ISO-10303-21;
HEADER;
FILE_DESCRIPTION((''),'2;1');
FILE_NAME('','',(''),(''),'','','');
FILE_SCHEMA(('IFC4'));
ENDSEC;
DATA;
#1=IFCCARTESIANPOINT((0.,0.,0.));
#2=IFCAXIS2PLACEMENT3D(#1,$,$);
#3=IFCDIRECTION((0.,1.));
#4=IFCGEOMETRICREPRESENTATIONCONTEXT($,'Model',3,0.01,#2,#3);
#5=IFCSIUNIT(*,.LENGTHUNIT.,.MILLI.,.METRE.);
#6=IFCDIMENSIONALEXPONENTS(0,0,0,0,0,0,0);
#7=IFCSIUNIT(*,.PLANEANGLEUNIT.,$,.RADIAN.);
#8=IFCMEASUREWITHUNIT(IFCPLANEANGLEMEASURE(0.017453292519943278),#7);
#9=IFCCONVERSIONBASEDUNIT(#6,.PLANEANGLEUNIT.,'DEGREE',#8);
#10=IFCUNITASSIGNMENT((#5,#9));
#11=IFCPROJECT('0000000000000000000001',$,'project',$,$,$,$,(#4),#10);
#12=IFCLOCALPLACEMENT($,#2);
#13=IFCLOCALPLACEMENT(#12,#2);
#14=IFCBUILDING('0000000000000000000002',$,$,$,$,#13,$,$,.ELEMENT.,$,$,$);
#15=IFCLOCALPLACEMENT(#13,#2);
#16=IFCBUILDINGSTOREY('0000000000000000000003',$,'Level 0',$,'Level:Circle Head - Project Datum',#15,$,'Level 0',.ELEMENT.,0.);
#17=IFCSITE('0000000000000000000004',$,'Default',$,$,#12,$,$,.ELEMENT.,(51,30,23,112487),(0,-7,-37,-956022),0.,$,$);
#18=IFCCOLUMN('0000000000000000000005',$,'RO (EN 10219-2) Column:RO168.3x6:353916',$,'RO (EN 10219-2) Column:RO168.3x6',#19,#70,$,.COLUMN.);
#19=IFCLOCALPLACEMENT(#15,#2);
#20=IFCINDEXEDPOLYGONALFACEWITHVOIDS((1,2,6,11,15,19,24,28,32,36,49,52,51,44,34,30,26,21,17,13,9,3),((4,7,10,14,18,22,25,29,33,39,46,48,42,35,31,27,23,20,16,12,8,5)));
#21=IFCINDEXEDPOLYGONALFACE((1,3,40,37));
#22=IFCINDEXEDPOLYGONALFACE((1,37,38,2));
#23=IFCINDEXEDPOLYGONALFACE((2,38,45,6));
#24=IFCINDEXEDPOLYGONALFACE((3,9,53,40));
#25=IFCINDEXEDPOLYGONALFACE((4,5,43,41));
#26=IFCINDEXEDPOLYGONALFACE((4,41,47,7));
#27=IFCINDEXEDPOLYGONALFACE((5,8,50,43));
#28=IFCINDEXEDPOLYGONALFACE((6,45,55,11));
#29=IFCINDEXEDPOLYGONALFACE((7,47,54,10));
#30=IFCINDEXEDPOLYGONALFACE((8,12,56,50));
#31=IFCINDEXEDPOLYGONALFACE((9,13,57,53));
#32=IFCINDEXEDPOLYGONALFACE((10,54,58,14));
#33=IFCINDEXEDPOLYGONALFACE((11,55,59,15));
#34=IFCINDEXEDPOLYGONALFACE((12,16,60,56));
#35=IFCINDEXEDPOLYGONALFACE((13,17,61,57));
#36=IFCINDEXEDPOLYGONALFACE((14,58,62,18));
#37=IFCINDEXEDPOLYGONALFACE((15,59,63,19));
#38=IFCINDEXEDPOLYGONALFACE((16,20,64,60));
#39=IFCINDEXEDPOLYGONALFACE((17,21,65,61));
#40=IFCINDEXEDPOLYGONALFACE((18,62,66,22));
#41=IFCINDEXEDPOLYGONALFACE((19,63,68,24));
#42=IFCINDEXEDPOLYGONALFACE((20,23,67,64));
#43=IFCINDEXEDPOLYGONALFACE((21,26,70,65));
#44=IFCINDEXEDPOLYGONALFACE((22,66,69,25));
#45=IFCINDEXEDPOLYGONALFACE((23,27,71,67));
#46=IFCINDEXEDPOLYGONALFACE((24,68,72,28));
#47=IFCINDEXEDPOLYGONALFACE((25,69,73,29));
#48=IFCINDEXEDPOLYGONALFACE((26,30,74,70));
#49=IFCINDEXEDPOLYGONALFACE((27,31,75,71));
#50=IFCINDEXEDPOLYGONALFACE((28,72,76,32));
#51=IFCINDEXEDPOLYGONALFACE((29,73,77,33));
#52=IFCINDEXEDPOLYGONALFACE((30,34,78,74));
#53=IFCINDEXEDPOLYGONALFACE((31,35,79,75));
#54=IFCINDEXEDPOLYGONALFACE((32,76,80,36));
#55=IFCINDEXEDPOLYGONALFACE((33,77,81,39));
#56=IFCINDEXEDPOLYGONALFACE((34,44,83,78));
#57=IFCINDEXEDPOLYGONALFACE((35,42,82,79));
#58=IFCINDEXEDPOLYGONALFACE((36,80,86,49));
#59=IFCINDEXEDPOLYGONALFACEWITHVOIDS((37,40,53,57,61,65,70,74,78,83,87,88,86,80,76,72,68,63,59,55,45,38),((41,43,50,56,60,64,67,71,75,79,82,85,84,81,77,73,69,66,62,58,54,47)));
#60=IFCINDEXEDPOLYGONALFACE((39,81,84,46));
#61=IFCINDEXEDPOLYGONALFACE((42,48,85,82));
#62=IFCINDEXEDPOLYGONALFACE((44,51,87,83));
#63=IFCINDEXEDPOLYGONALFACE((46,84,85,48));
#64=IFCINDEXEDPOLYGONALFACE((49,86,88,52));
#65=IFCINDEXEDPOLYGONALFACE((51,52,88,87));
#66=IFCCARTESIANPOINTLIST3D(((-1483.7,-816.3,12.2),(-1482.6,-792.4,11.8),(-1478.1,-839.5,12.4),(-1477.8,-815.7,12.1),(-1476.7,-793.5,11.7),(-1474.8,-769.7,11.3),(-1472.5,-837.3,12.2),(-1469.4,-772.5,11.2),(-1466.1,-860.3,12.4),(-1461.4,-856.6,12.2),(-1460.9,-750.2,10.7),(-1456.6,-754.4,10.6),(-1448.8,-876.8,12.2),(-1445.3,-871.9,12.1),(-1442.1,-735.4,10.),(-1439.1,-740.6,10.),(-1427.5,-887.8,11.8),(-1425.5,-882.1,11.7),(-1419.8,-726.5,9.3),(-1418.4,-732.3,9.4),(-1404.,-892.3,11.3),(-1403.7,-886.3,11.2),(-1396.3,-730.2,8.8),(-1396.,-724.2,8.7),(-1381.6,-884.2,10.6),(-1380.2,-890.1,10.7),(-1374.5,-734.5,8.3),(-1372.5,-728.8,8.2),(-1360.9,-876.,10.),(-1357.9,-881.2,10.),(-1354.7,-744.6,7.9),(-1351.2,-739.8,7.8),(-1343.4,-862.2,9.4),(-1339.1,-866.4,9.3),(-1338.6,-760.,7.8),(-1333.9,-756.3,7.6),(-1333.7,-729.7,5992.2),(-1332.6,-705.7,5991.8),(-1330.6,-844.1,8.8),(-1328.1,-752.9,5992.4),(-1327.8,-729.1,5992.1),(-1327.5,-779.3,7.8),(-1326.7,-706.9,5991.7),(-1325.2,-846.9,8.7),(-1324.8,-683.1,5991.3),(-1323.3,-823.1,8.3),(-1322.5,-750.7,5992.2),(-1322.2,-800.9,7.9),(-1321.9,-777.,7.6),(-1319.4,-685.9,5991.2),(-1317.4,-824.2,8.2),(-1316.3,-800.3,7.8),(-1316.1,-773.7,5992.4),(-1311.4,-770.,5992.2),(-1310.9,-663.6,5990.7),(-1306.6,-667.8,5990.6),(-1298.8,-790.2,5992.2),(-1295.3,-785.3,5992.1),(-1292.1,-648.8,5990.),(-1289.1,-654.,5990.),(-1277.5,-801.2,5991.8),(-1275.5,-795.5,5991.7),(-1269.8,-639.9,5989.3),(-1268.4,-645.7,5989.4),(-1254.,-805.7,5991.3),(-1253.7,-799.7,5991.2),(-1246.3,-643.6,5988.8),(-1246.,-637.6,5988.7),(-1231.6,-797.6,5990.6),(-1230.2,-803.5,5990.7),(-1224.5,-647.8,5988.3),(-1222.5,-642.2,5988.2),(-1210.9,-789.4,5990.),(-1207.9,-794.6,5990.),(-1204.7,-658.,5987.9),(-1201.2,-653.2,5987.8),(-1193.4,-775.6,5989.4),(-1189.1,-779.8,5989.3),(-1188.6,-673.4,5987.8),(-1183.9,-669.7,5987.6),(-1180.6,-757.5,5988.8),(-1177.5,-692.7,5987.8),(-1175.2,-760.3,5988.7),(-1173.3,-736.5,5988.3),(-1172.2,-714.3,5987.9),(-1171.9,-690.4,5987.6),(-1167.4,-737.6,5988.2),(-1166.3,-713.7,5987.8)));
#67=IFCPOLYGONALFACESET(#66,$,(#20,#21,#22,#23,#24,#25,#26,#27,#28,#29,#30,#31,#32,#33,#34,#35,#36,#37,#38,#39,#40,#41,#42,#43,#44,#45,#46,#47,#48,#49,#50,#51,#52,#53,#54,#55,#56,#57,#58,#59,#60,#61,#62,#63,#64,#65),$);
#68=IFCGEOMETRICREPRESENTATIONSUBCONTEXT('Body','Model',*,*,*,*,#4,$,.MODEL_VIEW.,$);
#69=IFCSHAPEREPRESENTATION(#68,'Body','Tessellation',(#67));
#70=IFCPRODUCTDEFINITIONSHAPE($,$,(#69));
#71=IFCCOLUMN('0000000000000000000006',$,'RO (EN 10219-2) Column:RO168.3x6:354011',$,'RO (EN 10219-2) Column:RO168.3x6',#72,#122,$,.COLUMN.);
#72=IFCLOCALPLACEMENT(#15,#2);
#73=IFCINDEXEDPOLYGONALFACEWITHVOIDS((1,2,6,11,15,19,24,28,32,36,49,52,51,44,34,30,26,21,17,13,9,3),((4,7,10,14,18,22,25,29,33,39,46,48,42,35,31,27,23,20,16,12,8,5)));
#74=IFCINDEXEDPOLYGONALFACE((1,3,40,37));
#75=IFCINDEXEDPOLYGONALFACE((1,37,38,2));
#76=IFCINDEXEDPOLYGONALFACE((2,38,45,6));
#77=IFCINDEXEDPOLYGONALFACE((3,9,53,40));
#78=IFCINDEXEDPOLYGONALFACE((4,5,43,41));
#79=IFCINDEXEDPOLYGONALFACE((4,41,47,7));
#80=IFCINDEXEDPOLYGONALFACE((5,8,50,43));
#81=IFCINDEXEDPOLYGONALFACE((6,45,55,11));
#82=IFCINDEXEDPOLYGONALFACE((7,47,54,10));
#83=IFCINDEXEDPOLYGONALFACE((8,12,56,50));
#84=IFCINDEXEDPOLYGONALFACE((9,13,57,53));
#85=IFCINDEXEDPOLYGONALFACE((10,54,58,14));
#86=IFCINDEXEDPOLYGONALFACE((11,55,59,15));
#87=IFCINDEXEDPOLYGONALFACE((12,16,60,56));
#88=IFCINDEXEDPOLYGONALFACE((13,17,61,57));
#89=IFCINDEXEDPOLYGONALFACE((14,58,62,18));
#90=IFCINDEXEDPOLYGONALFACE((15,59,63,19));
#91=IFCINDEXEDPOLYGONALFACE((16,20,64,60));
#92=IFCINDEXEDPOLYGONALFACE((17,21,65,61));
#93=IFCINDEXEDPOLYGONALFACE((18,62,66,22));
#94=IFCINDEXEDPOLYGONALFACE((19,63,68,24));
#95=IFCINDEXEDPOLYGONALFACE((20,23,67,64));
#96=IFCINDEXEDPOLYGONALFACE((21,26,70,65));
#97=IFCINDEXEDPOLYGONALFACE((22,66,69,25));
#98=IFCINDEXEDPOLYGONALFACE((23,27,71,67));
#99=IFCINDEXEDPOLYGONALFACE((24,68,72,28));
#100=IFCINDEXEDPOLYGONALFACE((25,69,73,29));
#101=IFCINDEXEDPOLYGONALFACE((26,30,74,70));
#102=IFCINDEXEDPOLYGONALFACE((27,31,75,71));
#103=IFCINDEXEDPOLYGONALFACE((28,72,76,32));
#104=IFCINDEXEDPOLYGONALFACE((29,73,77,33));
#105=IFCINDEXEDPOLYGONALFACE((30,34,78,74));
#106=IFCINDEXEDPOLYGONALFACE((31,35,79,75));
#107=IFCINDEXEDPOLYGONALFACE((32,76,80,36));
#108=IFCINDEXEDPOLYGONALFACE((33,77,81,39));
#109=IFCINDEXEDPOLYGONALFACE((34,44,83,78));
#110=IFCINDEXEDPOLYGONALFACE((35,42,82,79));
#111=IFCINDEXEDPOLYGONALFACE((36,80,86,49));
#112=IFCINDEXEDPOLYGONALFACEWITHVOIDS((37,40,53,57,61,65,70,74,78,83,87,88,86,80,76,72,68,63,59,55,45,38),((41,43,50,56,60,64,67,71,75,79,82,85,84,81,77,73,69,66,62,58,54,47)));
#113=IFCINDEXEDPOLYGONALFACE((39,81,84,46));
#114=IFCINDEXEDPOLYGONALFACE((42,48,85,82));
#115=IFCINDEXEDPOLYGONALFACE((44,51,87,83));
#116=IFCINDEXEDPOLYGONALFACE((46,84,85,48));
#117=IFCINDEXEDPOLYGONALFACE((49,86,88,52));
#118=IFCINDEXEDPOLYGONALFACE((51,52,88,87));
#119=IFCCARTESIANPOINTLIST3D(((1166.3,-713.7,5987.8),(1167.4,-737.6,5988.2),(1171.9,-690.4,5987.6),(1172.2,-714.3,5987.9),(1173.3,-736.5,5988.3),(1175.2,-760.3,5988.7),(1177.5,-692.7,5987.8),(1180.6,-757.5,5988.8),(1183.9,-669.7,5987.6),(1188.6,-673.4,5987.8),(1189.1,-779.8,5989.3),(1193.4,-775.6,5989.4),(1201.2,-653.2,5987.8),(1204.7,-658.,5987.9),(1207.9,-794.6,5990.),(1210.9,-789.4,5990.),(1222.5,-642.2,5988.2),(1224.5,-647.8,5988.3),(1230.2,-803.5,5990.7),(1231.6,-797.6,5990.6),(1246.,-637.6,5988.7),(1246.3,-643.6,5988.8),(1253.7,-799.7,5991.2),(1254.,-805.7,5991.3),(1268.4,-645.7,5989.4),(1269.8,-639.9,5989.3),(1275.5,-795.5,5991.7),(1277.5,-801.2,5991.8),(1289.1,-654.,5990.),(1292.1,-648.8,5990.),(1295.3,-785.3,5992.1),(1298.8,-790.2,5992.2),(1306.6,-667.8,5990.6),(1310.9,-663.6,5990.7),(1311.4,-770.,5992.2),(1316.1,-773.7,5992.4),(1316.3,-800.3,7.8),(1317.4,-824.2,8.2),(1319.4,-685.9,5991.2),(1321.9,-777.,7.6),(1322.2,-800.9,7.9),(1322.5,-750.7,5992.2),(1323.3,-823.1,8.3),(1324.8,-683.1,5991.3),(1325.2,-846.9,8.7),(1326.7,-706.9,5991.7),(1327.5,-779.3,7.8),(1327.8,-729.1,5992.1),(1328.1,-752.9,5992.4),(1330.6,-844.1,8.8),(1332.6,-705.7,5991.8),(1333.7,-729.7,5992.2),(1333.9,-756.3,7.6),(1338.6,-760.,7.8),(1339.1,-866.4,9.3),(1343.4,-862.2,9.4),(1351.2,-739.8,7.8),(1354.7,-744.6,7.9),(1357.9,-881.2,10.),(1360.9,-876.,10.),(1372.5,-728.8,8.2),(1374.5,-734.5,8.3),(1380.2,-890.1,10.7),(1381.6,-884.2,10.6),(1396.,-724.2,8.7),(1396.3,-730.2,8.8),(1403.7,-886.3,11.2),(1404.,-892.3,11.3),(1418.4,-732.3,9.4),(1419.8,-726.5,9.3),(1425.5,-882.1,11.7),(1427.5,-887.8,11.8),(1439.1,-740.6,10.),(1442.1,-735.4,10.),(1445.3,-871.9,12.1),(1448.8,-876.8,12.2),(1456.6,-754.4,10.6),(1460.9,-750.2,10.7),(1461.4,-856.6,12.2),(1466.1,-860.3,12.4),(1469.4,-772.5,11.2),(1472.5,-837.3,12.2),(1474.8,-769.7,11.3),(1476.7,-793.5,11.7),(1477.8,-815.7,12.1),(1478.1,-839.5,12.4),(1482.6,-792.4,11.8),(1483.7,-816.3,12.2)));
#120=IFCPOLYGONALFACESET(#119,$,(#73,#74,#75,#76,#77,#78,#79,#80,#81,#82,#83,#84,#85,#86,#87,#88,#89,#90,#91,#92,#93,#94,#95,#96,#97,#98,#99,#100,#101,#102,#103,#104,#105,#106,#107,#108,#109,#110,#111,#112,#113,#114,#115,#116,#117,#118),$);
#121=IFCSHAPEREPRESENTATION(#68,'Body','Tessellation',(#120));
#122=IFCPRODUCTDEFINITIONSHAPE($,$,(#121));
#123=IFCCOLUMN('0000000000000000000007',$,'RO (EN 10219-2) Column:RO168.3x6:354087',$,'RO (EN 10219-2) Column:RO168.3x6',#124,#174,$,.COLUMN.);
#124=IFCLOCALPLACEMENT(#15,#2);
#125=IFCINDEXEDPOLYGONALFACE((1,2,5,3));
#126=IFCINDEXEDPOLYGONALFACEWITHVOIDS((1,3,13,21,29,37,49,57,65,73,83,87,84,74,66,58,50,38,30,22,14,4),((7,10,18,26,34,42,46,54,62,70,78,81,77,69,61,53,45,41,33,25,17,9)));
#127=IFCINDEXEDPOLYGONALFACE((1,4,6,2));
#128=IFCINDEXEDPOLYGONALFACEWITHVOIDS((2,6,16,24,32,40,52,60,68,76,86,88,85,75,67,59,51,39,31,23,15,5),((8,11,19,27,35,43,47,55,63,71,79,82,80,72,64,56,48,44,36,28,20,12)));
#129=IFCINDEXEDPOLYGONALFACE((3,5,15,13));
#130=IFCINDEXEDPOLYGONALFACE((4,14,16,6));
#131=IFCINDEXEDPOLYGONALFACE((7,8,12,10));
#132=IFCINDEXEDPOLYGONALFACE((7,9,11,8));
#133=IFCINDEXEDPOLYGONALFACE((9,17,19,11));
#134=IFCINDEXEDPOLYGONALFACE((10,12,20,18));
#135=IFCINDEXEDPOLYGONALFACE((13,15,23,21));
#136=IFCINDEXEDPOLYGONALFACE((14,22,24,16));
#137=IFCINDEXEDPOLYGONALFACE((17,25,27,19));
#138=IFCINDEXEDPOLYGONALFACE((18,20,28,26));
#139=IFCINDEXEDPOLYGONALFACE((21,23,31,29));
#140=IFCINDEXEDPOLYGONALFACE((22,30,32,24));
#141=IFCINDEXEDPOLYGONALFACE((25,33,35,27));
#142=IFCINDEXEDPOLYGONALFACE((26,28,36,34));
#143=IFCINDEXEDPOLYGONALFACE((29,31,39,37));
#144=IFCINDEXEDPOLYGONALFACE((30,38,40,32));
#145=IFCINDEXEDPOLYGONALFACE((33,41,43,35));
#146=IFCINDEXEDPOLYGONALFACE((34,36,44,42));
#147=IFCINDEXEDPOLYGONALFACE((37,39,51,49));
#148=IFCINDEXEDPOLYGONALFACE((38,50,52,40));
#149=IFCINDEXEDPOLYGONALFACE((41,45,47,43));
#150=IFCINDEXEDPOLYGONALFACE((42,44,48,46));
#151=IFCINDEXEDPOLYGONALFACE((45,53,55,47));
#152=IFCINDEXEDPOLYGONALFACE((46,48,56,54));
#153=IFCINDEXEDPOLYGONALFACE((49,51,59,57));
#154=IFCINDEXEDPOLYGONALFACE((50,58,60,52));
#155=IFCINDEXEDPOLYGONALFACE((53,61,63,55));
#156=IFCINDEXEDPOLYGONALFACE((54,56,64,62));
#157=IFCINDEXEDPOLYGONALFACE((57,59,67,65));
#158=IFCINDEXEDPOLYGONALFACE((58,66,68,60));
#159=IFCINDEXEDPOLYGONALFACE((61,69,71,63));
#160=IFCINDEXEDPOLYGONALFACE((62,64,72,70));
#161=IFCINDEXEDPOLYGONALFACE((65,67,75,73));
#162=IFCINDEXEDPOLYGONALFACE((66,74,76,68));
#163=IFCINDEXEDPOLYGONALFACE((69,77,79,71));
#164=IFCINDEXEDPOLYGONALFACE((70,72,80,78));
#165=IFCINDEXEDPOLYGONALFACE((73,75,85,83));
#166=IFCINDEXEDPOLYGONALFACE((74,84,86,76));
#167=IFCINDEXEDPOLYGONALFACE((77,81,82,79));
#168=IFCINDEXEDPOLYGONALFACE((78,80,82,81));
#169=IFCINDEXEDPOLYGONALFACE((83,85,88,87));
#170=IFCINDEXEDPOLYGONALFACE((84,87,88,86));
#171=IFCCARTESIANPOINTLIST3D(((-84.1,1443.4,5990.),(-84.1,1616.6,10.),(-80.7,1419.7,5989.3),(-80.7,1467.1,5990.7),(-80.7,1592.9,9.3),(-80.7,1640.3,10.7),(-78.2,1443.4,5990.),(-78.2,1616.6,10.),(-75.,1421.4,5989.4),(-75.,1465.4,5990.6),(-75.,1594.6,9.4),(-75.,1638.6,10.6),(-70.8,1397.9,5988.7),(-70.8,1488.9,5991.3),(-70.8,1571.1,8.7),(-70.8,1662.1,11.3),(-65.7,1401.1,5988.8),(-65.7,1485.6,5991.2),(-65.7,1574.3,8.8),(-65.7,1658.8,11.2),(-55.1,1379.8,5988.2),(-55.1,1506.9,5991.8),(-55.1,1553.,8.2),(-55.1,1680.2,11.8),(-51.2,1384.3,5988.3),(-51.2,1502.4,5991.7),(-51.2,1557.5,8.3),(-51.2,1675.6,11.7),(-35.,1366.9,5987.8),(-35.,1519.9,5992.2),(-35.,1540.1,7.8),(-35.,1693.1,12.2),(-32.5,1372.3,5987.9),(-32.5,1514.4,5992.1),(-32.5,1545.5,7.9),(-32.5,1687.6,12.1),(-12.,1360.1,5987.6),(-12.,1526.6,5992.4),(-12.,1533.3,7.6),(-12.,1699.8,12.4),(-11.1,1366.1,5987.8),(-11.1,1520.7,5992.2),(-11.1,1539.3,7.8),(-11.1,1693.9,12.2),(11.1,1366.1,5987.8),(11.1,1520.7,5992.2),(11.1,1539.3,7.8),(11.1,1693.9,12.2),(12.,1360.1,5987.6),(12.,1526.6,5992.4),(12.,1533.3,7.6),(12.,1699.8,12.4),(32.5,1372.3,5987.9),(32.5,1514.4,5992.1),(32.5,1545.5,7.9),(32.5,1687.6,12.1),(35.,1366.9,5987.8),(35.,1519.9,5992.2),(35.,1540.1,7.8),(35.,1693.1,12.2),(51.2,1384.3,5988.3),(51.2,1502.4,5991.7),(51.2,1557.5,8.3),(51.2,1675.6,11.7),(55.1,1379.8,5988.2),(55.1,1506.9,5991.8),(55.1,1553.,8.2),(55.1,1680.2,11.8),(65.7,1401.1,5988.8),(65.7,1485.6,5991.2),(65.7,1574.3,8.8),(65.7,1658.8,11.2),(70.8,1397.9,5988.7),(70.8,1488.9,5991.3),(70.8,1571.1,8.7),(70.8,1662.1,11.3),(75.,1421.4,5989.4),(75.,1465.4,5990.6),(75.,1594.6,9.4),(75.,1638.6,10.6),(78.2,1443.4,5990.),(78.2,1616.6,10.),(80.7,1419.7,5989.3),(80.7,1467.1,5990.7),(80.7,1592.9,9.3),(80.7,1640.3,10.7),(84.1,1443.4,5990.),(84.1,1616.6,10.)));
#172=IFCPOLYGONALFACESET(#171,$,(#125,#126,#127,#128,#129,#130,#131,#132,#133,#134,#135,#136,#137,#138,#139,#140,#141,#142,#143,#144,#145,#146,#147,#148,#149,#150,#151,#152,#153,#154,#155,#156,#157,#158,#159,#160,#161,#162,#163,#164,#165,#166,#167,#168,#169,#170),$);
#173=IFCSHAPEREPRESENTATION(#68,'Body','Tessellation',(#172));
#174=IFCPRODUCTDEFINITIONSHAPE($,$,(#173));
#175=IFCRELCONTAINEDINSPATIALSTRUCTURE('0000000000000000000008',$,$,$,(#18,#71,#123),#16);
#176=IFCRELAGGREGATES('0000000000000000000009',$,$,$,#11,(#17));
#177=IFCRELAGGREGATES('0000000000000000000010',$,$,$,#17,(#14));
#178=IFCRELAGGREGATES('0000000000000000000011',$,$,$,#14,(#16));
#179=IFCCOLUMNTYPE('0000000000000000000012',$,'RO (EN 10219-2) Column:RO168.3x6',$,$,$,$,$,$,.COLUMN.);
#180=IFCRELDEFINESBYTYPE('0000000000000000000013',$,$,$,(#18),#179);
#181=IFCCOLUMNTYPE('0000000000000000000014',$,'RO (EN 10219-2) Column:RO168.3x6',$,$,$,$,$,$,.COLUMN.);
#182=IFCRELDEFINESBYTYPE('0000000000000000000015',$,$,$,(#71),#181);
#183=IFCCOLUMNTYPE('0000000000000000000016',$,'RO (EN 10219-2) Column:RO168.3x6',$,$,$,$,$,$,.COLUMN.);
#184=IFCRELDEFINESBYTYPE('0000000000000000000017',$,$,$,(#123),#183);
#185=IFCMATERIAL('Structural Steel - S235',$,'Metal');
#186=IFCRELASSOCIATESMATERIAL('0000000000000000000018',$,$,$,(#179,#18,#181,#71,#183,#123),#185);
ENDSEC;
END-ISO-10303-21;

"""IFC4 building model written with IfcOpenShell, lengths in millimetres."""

from ifc_helpers import new_model, entity, si_unit, converted_unit, direction, frame, origin, place, context, subcontext, project, spatial, arc, indexed_curve, outline, extrude, source, transform, mapped, material, type_object, type_shapes, element, save


model = new_model("IFC4")

# Units and contexts
model_context = context("Model", 3, precision=0.01, world=origin(), true_north=direction((0.0, 1.0)))
body_context = subcontext(model_context, "Body", "Model", "MODEL_VIEW")
ifc_project = project(units=[si_unit("LENGTHUNIT", "METRE", prefix="MILLI"), converted_unit("PLANEANGLEUNIT", "DEGREE", entity("IfcPlaneAngleMeasure", 0.017453292519943278), si_unit("PLANEANGLEUNIT", "RADIAN"), dimensions=[0, 0, 0, 0, 0, 0, 0])], contexts=[model_context])

# Site, building, storey
site_placement = place(None, origin())
site = spatial("IfcSite", under=ifc_project, at=site_placement, Name="Default", CompositionType="ELEMENT", RefLatitude=(51, 30, 23, 112487), RefLongitude=(0, -7, -37, -956022), RefElevation=0.0)
building_placement = place(site_placement, origin())
building = spatial("IfcBuilding", under=site, at=building_placement, CompositionType="ELEMENT")
storey_placement = place(building_placement, origin())
storey = spatial("IfcBuildingStorey", under=building, at=storey_placement, Name="Level 0", ObjectType="Level:Circle Head - Project Datum", LongName="Level 0", CompositionType="ELEMENT", Elevation=0.0)

# Columns
ifc_material_1 = material(Name="Structural Steel - S235", Category="Metal")
column_type_1 = type_object("IfcColumnType", Name="RO (EN 10219-2) Column:RO168.3x6", PredefinedType="COLUMN", material=ifc_material_1)
shared_shape_1 = source(origin(), body_context, "Body", "SweptSolid", [
    extrude(outline(indexed_curve([(-84.1, 0.0), (0.0, -84.1), (84.1, 0.0), (0.0, 84.1)], segments=[arc(1, 2, 3), arc(3, 4, 1)], self_intersect=False), holes=[indexed_curve([(-78.2, 0.0), (0.0, 78.2), (78.2, 0.0), (0.0, -78.2)], segments=[arc(1, 2, 3), arc(3, 4, 1)], self_intersect=False)]), frame((-1400.0, -808.3, 10.0), z_axis=(0.025073, 0.014476, 0.999581), x_axis=(-0.5, 0.866025, 0.0)), (0.0, 0.0, 1.0), 5982.5),
])
type_shapes(column_type_1, [shared_shape_1])
column_1_placement = place(storey_placement, origin())
element("IfcColumn", 1, at=column_1_placement, inside=storey, type_object=column_type_1, material=ifc_material_1, Name="RO (EN 10219-2) Column:RO168.3x6:353916", ObjectType="RO (EN 10219-2) Column:RO168.3x6", PredefinedType="COLUMN", context=body_context, shape_type="MappedRepresentation", body=[
    mapped(shared_shape_1, transform((0.0, 0.0, 0.0), scale=1.0)),
])
column_type_2 = type_object("IfcColumnType", Name="RO (EN 10219-2) Column:RO168.3x6", PredefinedType="COLUMN", material=ifc_material_1)
shared_shape_2 = source(origin(), body_context, "Body", "SweptSolid", [
    extrude(outline(indexed_curve([(-84.2, 0.0), (0.0, -84.1), (84.1, 0.0), (0.0, 84.1)], segments=[arc(1, 2, 3), arc(3, 4, 1)], self_intersect=False), holes=[indexed_curve([(-78.2, 0.0), (0.0, 78.2), (78.2, 0.0), (0.0, -78.2)], segments=[arc(1, 2, 3), arc(3, 4, 1)], self_intersect=False)]), frame((1250.0, -721.7, 5990.0), z_axis=(0.025073, -0.014476, -0.999581), x_axis=(-0.5, -0.866025, 0.0)), (0.0, 0.0, 1.0), 5982.5),
])
type_shapes(column_type_2, [shared_shape_2])
column_2_placement = place(storey_placement, origin())
element("IfcColumn", 2, at=column_2_placement, inside=storey, type_object=column_type_2, material=ifc_material_1, Name="RO (EN 10219-2) Column:RO168.3x6:354011", ObjectType="RO (EN 10219-2) Column:RO168.3x6", PredefinedType="COLUMN", context=body_context, shape_type="MappedRepresentation", body=[
    mapped(shared_shape_2, transform((0.0, 0.0, 0.0), scale=1.0)),
])
column_type_3 = type_object("IfcColumnType", Name="RO (EN 10219-2) Column:RO168.3x6", PredefinedType="COLUMN", material=ifc_material_1)
shared_shape_3 = source(origin(), body_context, "Body", "SweptSolid", [
    extrude(outline(indexed_curve([(-84.1, 0.0), (0.0, -84.1), (84.1, 0.0), (0.0, 84.1)], segments=[arc(1, 2, 3), arc(3, 4, 1)], self_intersect=False), holes=[indexed_curve([(-78.2, 0.0), (0.0, 78.2), (78.2, 0.0), (0.0, -78.2)], segments=[arc(1, 2, 3), arc(3, 4, 1)], self_intersect=False)]), frame((0.0, 1443.4, 5990.0), z_axis=(0.0, 0.028952, -0.999581), x_axis=(1.0, 0.0, 0.0)), (0.0, 0.0, 1.0), 5982.5),
])
type_shapes(column_type_3, [shared_shape_3])
column_3_placement = place(storey_placement, origin())
element("IfcColumn", 3, at=column_3_placement, inside=storey, type_object=column_type_3, material=ifc_material_1, Name="RO (EN 10219-2) Column:RO168.3x6:354087", ObjectType="RO (EN 10219-2) Column:RO168.3x6", PredefinedType="COLUMN", context=body_context, shape_type="MappedRepresentation", body=[
    mapped(shared_shape_3, transform((0.0, 0.0, 0.0), scale=1.0)),
])

save(model, "model.ifc")
